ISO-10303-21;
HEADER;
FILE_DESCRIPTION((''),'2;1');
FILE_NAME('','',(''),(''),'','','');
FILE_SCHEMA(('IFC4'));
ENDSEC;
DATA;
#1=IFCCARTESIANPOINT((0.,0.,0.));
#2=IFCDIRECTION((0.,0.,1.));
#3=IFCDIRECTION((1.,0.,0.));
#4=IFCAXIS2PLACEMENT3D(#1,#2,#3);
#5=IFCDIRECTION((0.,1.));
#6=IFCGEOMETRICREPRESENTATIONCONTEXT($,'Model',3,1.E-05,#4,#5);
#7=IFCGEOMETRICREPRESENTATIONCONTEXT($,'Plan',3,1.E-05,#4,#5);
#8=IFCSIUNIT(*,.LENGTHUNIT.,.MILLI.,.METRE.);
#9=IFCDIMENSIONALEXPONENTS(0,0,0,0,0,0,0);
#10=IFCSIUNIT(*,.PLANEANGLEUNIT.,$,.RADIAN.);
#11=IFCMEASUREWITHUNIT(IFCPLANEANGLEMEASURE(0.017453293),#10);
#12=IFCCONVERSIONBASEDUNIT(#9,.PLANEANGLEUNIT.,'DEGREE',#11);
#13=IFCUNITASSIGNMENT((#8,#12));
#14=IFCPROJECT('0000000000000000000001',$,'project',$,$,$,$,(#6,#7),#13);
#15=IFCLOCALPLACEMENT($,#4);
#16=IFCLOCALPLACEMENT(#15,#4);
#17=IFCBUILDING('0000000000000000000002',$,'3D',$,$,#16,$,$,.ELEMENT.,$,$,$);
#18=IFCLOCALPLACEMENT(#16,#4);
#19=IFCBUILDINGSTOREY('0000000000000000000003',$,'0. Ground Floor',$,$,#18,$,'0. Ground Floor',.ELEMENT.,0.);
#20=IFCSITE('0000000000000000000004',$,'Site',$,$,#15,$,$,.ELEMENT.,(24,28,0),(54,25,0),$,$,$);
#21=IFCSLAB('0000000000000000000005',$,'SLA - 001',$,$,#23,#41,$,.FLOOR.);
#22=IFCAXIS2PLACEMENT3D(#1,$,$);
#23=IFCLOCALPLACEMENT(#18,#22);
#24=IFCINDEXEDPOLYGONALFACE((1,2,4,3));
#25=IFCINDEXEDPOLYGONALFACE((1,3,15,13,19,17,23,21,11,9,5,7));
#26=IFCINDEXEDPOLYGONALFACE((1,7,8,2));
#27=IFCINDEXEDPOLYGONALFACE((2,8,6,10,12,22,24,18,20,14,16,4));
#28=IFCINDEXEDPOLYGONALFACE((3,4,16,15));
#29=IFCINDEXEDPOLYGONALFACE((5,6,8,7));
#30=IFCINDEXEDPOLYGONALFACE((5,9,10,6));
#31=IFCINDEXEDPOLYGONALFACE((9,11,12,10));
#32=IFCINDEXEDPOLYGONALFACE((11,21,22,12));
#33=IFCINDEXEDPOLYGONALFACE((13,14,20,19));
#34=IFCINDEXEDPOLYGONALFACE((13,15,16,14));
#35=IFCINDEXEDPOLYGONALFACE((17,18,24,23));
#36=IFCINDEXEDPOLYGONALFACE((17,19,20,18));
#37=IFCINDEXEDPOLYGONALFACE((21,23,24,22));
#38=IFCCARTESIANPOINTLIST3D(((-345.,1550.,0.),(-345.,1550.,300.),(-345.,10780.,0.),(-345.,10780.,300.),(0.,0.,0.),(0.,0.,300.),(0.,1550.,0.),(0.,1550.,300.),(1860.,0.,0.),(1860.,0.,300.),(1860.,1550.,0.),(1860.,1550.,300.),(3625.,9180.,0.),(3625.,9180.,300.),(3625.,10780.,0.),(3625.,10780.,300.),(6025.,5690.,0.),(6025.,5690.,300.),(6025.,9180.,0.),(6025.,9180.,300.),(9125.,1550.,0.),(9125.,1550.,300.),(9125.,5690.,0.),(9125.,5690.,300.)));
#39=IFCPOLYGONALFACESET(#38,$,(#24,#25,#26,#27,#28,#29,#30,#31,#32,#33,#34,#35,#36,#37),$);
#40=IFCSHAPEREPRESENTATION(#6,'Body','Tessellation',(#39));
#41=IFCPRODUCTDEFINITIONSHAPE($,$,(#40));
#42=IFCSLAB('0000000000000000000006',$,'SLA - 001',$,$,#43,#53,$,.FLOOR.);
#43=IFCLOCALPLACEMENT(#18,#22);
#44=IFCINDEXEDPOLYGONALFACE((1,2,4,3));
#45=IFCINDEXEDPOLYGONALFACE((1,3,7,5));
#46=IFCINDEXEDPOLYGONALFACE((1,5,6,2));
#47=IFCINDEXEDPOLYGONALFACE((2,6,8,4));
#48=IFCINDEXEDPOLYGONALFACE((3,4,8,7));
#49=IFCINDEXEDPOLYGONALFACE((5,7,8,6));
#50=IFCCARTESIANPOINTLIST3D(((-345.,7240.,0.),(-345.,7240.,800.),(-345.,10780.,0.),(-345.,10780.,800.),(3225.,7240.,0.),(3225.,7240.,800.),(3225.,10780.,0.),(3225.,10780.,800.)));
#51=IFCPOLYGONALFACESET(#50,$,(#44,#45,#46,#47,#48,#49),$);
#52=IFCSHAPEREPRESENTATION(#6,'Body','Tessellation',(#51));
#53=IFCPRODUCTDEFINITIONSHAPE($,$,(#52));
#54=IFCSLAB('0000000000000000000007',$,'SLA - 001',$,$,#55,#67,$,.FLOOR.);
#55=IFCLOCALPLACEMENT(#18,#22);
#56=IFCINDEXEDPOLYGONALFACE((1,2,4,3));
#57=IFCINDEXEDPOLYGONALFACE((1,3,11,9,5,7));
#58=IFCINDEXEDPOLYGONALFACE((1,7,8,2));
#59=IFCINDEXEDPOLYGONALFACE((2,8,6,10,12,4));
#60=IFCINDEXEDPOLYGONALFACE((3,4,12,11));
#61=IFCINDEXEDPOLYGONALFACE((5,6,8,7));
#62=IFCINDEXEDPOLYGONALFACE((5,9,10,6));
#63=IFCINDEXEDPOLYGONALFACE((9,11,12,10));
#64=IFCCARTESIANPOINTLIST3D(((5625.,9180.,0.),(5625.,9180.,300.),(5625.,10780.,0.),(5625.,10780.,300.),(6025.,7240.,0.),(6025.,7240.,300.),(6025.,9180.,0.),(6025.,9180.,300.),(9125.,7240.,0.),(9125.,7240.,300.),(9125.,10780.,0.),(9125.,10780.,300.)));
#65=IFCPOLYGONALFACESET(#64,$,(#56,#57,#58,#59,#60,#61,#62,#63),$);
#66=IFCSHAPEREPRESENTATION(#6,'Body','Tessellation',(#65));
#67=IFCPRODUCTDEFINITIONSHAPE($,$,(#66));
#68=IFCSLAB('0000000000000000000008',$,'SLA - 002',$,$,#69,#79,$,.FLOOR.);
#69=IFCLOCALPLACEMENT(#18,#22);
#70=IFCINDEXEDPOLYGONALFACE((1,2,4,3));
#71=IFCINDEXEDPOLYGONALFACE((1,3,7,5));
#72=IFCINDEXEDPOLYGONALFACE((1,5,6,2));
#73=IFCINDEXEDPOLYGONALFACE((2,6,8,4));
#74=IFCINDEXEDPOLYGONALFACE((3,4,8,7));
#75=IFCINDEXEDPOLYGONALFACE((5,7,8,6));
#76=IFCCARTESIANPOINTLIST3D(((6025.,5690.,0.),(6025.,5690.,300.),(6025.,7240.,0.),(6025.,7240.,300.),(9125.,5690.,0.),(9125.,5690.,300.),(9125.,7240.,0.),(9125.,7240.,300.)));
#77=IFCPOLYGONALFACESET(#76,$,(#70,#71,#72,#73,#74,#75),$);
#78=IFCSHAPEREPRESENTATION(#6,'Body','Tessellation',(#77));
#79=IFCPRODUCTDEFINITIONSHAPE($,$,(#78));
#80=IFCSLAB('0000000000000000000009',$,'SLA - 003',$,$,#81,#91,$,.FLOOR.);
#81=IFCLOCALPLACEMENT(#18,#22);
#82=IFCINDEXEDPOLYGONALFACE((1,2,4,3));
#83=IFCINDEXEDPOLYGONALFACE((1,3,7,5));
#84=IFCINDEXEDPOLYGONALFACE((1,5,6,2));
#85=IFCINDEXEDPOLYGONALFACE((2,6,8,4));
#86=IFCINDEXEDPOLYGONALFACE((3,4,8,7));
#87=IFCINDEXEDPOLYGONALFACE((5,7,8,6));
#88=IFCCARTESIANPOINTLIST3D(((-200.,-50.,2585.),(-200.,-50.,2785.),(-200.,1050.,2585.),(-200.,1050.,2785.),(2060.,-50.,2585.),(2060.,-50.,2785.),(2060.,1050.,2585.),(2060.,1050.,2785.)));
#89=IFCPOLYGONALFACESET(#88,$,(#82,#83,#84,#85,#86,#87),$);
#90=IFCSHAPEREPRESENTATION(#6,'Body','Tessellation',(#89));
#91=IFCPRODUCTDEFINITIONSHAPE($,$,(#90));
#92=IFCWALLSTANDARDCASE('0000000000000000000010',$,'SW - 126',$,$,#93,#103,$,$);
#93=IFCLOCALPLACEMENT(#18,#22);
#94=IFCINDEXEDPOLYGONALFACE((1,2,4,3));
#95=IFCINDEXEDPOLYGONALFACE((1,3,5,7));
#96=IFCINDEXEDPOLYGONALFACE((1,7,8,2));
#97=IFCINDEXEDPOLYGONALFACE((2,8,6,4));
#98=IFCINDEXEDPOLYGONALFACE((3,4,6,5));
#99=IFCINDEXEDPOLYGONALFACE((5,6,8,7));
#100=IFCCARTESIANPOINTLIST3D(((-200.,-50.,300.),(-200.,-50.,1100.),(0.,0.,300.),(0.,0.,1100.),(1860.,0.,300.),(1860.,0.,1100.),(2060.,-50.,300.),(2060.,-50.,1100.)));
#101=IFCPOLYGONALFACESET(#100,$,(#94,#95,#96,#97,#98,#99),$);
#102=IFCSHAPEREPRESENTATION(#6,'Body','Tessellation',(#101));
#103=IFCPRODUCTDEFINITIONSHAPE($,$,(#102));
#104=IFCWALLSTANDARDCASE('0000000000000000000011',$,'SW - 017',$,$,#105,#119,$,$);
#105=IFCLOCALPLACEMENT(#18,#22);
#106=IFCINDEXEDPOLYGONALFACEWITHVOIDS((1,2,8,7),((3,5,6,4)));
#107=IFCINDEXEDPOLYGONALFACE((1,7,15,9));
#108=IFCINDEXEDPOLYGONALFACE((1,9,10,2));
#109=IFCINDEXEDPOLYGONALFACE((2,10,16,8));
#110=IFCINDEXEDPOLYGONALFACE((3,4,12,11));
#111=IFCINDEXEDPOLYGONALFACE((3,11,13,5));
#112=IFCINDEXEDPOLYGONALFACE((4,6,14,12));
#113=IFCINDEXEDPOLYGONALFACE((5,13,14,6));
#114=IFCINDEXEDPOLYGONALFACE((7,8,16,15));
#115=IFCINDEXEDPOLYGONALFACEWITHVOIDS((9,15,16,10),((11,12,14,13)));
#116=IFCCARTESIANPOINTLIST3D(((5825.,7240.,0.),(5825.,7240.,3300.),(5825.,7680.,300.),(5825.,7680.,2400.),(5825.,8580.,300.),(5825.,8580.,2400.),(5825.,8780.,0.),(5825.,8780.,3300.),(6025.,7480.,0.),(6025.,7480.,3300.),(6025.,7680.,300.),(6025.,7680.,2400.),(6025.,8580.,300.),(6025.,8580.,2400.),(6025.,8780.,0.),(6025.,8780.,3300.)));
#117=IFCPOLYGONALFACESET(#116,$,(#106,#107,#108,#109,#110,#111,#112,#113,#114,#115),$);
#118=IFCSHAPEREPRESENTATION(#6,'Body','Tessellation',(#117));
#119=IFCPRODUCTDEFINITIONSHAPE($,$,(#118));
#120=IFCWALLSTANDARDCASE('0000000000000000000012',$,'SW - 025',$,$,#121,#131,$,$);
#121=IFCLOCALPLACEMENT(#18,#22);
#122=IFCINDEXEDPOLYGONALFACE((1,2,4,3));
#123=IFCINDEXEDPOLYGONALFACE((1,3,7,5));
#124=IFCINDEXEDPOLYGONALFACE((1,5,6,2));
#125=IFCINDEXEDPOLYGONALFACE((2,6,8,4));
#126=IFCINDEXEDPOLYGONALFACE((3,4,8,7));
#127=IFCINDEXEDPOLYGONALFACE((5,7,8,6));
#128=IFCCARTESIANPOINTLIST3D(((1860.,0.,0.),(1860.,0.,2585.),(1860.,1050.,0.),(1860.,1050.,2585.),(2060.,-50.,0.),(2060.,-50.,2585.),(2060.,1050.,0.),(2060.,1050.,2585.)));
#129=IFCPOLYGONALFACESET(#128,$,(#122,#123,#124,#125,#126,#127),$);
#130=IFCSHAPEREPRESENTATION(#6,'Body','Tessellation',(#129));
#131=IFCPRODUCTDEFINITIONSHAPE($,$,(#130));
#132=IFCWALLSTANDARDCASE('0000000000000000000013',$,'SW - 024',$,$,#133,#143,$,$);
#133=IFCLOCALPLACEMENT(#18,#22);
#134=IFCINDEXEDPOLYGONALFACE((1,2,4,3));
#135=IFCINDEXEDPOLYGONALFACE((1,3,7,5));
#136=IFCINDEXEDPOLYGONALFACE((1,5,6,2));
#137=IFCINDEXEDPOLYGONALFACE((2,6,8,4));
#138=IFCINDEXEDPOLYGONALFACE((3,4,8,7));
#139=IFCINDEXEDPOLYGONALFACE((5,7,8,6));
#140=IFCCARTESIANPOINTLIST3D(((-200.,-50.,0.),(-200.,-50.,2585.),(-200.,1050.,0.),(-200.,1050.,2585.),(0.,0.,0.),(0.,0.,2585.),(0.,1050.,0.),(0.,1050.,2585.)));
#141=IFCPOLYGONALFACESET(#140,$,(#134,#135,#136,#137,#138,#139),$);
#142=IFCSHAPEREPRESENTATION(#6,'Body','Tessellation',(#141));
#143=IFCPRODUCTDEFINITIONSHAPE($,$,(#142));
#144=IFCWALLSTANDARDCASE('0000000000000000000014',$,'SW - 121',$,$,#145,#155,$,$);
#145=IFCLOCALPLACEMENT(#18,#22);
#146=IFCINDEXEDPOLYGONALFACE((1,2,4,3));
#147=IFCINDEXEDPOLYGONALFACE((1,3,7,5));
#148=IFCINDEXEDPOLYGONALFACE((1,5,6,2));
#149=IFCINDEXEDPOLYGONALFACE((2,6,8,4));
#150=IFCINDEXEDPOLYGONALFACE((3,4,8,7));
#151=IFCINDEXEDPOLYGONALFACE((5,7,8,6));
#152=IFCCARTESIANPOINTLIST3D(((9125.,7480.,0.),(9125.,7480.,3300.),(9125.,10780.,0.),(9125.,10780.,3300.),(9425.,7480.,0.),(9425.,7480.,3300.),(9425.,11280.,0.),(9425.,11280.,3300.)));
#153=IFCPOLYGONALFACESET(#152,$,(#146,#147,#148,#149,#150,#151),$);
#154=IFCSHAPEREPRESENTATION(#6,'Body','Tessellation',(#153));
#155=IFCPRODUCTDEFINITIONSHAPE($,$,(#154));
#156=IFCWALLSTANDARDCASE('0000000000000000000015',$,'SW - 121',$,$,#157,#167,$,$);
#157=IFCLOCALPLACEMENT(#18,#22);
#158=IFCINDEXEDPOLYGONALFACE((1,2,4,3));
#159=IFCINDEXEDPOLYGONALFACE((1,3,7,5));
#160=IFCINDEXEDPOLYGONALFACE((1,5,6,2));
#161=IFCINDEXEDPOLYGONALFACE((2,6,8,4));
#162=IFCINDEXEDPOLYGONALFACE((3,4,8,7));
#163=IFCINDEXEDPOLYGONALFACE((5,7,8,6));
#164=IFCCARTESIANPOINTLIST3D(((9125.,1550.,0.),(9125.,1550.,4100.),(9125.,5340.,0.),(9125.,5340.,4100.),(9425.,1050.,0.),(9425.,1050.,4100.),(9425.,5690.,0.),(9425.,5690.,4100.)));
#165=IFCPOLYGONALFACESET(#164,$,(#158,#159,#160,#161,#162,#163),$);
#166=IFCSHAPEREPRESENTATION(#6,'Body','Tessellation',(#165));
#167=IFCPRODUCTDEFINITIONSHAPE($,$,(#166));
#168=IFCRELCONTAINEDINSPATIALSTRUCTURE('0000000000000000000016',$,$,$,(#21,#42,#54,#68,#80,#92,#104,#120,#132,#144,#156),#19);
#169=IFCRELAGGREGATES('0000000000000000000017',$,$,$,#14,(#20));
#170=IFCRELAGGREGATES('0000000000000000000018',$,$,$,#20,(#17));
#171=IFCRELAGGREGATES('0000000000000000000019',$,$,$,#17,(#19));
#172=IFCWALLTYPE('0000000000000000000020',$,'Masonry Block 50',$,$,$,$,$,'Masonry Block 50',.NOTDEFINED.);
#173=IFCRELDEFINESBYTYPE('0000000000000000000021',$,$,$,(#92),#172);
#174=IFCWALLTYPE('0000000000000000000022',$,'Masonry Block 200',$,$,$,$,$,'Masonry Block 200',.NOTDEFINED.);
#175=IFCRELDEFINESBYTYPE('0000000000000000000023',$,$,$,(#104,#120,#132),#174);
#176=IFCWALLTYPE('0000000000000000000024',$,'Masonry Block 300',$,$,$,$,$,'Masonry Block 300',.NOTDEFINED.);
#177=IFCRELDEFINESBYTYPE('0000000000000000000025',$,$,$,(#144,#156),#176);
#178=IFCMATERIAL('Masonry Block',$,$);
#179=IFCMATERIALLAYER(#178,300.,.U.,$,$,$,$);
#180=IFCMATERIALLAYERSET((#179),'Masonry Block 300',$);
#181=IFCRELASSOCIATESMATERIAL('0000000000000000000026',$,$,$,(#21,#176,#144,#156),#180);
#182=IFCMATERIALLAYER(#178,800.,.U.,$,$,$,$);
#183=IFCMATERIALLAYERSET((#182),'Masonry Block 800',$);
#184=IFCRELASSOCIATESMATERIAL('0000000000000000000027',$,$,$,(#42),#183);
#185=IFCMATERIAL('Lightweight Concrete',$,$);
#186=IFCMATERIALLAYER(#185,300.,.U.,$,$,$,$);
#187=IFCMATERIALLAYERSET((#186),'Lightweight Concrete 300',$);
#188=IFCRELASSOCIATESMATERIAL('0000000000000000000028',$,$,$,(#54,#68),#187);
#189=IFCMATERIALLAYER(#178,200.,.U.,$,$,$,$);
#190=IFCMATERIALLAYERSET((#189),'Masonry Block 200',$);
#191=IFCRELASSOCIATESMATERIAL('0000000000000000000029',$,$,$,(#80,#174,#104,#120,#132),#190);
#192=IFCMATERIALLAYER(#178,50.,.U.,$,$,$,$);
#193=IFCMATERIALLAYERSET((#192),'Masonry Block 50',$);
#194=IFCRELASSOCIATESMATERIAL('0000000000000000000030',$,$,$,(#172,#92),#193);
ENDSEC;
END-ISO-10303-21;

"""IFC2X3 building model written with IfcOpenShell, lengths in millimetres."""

from ifc_helpers import new_model, entity, si_unit, converted_unit, direction, frame, frame_2d, origin_with_axes, place, context, project, spatial, polyline, rectangle, outline, extrude, material, layer, layer_set, layer_usage, type_object, element, save


model = new_model("IFC2X3")

# Units and contexts
model_context = context("Model", 3, precision=1e-05, world=origin_with_axes(), true_north=direction((0.0, 1.0)))
plan_context = context("Plan", 3, precision=1e-05, world=origin_with_axes(), true_north=direction((0.0, 1.0)))
ifc_project = project(units=[si_unit("LENGTHUNIT", "METRE", prefix="MILLI"), converted_unit("PLANEANGLEUNIT", "DEGREE", entity("IfcPlaneAngleMeasure", 0.017453293), si_unit("PLANEANGLEUNIT", "RADIAN"), dimensions=[0, 0, 0, 0, 0, 0, 0])], contexts=[model_context, plan_context])

# Site, building, storey
site_placement = place(None, origin_with_axes())
site = spatial("IfcSite", under=ifc_project, at=site_placement, Name="Site", CompositionType="ELEMENT", RefLatitude=(24, 28, 0), RefLongitude=(54, 25, 0))
building_placement = place(site_placement, origin_with_axes())
building = spatial("IfcBuilding", under=site, at=building_placement, Name="3D", CompositionType="ELEMENT")
storey_placement = place(building_placement, origin_with_axes())
storey = spatial("IfcBuildingStorey", under=building, at=storey_placement, Name="0. Ground Floor", LongName="0. Ground Floor", CompositionType="ELEMENT", Elevation=0.0)

# Slabs
ifc_material_1 = material(Name="Masonry Block")
ifc_layer_1 = layer(ifc_material_1, 300.0, ventilated="UNKNOWN")
ifc_layer_set_1 = layer_set([ifc_layer_1], Name="Masonry Block 300")
ifc_layer_usage_1 = layer_usage(ifc_layer_set_1, "AXIS3", "NEGATIVE", 300.0)
slab_1_placement = place(storey_placement, frame((-345.0, 10780.0, 0.0), z_axis=(0.0, 0.0, 1.0), x_axis=(0.0, -1.0, 0.0)))
element("IfcSlab", 1, at=slab_1_placement, inside=storey, material=ifc_layer_usage_1, Name="SLA - 001", PredefinedType="FLOOR", context=model_context, shape_type="SweptSolid", body=[
    extrude(outline(polyline([(0.0, 0.0), (9230.0, 0.0), (9230.0, 345.0), (10780.0, 345.0), (10780.0, 2205.0), (9230.0, 2205.0), (9230.0, 9470.0), (5090.0, 9470.0), (5090.0, 6370.0), (1600.0, 6370.0), (1600.0, 3970.0), (0.0, 3970.0), (0.0, 0.0)])), origin_with_axes(), (0.0, 0.0, 1.0), 300.0),
])
ifc_layer_2 = layer(ifc_material_1, 800.0, ventilated="UNKNOWN")
ifc_layer_set_2 = layer_set([ifc_layer_2], Name="Masonry Block 800")
ifc_layer_usage_2 = layer_usage(ifc_layer_set_2, "AXIS3", "NEGATIVE", 800.0)
slab_2_placement = place(storey_placement, frame((-345.0, 10780.0, 0.0), z_axis=(0.0, 0.0, 1.0), x_axis=(1.0, 0.0, 0.0)))
element("IfcSlab", 2, at=slab_2_placement, inside=storey, material=ifc_layer_usage_2, Name="SLA - 001", PredefinedType="FLOOR", context=model_context, shape_type="SweptSolid", body=[
    extrude(outline(polyline([(0.0, 0.0), (3570.0, 0.0), (3570.0, -3540.0), (0.0, -3540.0), (0.0, 0.0)])), origin_with_axes(), (0.0, 0.0, 1.0), 800.0),
])
ifc_material_2 = material(Name="Lightweight Concrete")
ifc_layer_3 = layer(ifc_material_2, 300.0, ventilated="UNKNOWN")
ifc_layer_set_3 = layer_set([ifc_layer_3], Name="Lightweight Concrete 300")
ifc_layer_usage_3 = layer_usage(ifc_layer_set_3, "AXIS3", "NEGATIVE", 300.0)
slab_3_placement = place(storey_placement, frame((5625.0, 9180.0, 0.0), z_axis=(0.0, 0.0, 1.0), x_axis=(1.0, 0.0, 0.0)))
element("IfcSlab", 3, at=slab_3_placement, inside=storey, material=ifc_layer_usage_3, Name="SLA - 001", PredefinedType="FLOOR", context=model_context, shape_type="SweptSolid", body=[
    extrude(outline(polyline([(0.0, 0.0), (400.0, 0.0), (400.0, -1940.0), (3500.0, -1940.0), (3500.0, 1600.0), (0.0, 1600.0), (0.0, 0.0)])), origin_with_axes(), (0.0, 0.0, 1.0), 300.0),
])
ifc_layer_usage_4 = layer_usage(ifc_layer_set_3, "AXIS3", "NEGATIVE", 300.0)
slab_4_placement = place(storey_placement, frame((9125.0, 7240.0, 0.0), z_axis=(0.0, 0.0, 1.0), x_axis=(-1.0, 0.0, 0.0)))
element("IfcSlab", 4, at=slab_4_placement, inside=storey, material=ifc_layer_usage_4, Name="SLA - 002", PredefinedType="FLOOR", context=model_context, shape_type="SweptSolid", body=[
    extrude(outline(polyline([(0.0, 0.0), (3100.0, 0.0), (3100.0, 1550.0), (0.0, 1550.0), (0.0, 0.0)])), origin_with_axes(), (0.0, 0.0, 1.0), 300.0),
])
ifc_layer_4 = layer(ifc_material_1, 200.0, ventilated="UNKNOWN")
ifc_layer_set_4 = layer_set([ifc_layer_4], Name="Masonry Block 200")
ifc_layer_usage_5 = layer_usage(ifc_layer_set_4, "AXIS3", "NEGATIVE", 200.0)
slab_5_placement = place(storey_placement, frame((-200.0, 1050.0, 2585.0), z_axis=(0.0, 0.0, 1.0), x_axis=(1.0, 0.0, 0.0)))
element("IfcSlab", 5, at=slab_5_placement, inside=storey, material=ifc_layer_usage_5, Name="SLA - 003", PredefinedType="FLOOR", context=model_context, shape_type="SweptSolid", body=[
    extrude(outline(polyline([(0.0, 0.0), (2260.0, 0.0), (2260.0, -1100.0), (0.0, -1100.0), (0.0, 0.0)])), origin_with_axes(), (0.0, 0.0, 1.0), 200.0),
])

# Wall
ifc_layer_5 = layer(ifc_material_1, 50.0, ventilated="UNKNOWN")
ifc_layer_set_5 = layer_set([ifc_layer_5], Name="Masonry Block 50")
ifc_layer_usage_6 = layer_usage(ifc_layer_set_5, "AXIS2", "POSITIVE", 0.0)
wall_type_1 = type_object("IfcWallType", Name="Masonry Block 50", ElementType="Masonry Block 50", PredefinedType="NOTDEFINED", material=ifc_layer_set_5)
wall_1_placement = place(storey_placement, frame((0.0, -50.0, 300.0), z_axis=(0.0, 0.0, 1.0), x_axis=(1.0, 0.0, 0.0)))
element("IfcWallStandardCase", 6, at=wall_1_placement, inside=storey, type_object=wall_type_1, material=ifc_layer_usage_6, Name="SW - 126", context=model_context, shape_type="SweptSolid", body=[
    extrude(outline(polyline([(-200.0, 0.0), (2060.0, 0.0), (1860.0, 50.0), (0.0, 50.0), (-200.0, 0.0)])), origin_with_axes(), (0.0, 0.0, 1.0), 800.0),
])

# Wall, opening
ifc_layer_usage_7 = layer_usage(ifc_layer_set_4, "AXIS2", "NEGATIVE", 0.0)
wall_type_2 = type_object("IfcWallType", Name="Masonry Block 200", ElementType="Masonry Block 200", PredefinedType="NOTDEFINED", material=ifc_layer_set_4)
wall_2_placement = place(storey_placement, frame((6025.0, 8780.0, 0.0), z_axis=(0.0, 0.0, 1.0), x_axis=(0.0, -1.0, 0.0)))
wall_2 = element("IfcWallStandardCase", 7, at=wall_2_placement, inside=storey, type_object=wall_type_2, material=ifc_layer_usage_7, Name="SW - 017", context=model_context, shape_type="SweptSolid", body=[
    extrude(outline(polyline([(0.0, -200.0), (1540.0, -200.0), (1300.0, 0.0), (0.0, 0.0), (0.0, -200.0)])), origin_with_axes(), (0.0, 0.0, 1.0), 3300.0),
])
opening_1_placement = place(wall_2_placement, frame((650.0, -200.0, 300.0), z_axis=(0.0, 0.0, 1.0), x_axis=(1.0, 0.0, 0.0)))
element("IfcOpeningElement", 8, at=opening_1_placement, cuts=wall_2, ObjectType="Opening", context=model_context, shape_type="SweptSolid", body=[
    extrude(rectangle(XDim=900.0, YDim=2100.0, at=frame_2d((0.0, 1050.0), x_axis=(-1.0, 0.0))), frame((0.0, 0.0, 0.0), z_axis=(0.0, 1.0, 0.0), x_axis=(-1.0, 0.0, 0.0)), (0.0, 0.0, 1.0), 200.0),
])

# Walls
ifc_layer_usage_8 = layer_usage(ifc_layer_set_4, "AXIS2", "POSITIVE", 0.0)
wall_3_placement = place(storey_placement, frame((1860.0, 1050.0, 0.0), z_axis=(0.0, 0.0, 1.0), x_axis=(0.0, -1.0, 0.0)))
element("IfcWallStandardCase", 9, at=wall_3_placement, inside=storey, type_object=wall_type_2, material=ifc_layer_usage_8, Name="SW - 025", context=model_context, shape_type="SweptSolid", body=[
    extrude(outline(polyline([(0.0, 0.0), (1050.0, 0.0), (1100.0, 200.0), (0.0, 200.0), (0.0, 0.0)])), origin_with_axes(), (0.0, 0.0, 1.0), 2585.0),
])
ifc_layer_usage_9 = layer_usage(ifc_layer_set_4, "AXIS2", "NEGATIVE", 0.0)
wall_4_placement = place(storey_placement, frame((0.0, 1050.0, 0.0), z_axis=(0.0, 0.0, 1.0), x_axis=(0.0, -1.0, 0.0)))
element("IfcWallStandardCase", 10, at=wall_4_placement, inside=storey, type_object=wall_type_2, material=ifc_layer_usage_9, Name="SW - 024", context=model_context, shape_type="SweptSolid", body=[
    extrude(outline(polyline([(0.0, -200.0), (1100.0, -200.0), (1050.0, 0.0), (0.0, 0.0), (0.0, -200.0)])), origin_with_axes(), (0.0, 0.0, 1.0), 2585.0),
])
ifc_layer_usage_10 = layer_usage(ifc_layer_set_1, "AXIS2", "NEGATIVE", 0.0)
wall_type_3 = type_object("IfcWallType", Name="Masonry Block 300", ElementType="Masonry Block 300", PredefinedType="NOTDEFINED", material=ifc_layer_set_1)
wall_5_placement = place(storey_placement, frame((9425.0, 11280.0, 0.0), z_axis=(0.0, 0.0, 1.0), x_axis=(0.0, -1.0, 0.0)))
element("IfcWallStandardCase", 11, at=wall_5_placement, inside=storey, type_object=wall_type_3, material=ifc_layer_usage_10, Name="SW - 121", context=model_context, shape_type="SweptSolid", body=[
    extrude(outline(polyline([(500.0, -300.0), (3800.0, -300.0), (3800.0, 0.0), (0.0, 0.0), (500.0, -300.0)])), origin_with_axes(), (0.0, 0.0, 1.0), 3300.0),
])
ifc_layer_usage_11 = layer_usage(ifc_layer_set_1, "AXIS2", "NEGATIVE", 0.0)
wall_6_placement = place(storey_placement, frame((9425.0, 5340.0, 0.0), z_axis=(0.0, 0.0, 1.0), x_axis=(0.0, -1.0, 0.0)))
element("IfcWallStandardCase", 12, at=wall_6_placement, inside=storey, type_object=wall_type_3, material=ifc_layer_usage_11, Name="SW - 121", context=model_context, shape_type="SweptSolid", body=[
    extrude(outline(polyline([(0.0, -300.0), (3790.0, -300.0), (4290.0, 0.0), (-350.0, 0.0), (0.0, -300.0)])), origin_with_axes(), (0.0, 0.0, 1.0), 4100.0),
])

save(model, "model.ifc")
